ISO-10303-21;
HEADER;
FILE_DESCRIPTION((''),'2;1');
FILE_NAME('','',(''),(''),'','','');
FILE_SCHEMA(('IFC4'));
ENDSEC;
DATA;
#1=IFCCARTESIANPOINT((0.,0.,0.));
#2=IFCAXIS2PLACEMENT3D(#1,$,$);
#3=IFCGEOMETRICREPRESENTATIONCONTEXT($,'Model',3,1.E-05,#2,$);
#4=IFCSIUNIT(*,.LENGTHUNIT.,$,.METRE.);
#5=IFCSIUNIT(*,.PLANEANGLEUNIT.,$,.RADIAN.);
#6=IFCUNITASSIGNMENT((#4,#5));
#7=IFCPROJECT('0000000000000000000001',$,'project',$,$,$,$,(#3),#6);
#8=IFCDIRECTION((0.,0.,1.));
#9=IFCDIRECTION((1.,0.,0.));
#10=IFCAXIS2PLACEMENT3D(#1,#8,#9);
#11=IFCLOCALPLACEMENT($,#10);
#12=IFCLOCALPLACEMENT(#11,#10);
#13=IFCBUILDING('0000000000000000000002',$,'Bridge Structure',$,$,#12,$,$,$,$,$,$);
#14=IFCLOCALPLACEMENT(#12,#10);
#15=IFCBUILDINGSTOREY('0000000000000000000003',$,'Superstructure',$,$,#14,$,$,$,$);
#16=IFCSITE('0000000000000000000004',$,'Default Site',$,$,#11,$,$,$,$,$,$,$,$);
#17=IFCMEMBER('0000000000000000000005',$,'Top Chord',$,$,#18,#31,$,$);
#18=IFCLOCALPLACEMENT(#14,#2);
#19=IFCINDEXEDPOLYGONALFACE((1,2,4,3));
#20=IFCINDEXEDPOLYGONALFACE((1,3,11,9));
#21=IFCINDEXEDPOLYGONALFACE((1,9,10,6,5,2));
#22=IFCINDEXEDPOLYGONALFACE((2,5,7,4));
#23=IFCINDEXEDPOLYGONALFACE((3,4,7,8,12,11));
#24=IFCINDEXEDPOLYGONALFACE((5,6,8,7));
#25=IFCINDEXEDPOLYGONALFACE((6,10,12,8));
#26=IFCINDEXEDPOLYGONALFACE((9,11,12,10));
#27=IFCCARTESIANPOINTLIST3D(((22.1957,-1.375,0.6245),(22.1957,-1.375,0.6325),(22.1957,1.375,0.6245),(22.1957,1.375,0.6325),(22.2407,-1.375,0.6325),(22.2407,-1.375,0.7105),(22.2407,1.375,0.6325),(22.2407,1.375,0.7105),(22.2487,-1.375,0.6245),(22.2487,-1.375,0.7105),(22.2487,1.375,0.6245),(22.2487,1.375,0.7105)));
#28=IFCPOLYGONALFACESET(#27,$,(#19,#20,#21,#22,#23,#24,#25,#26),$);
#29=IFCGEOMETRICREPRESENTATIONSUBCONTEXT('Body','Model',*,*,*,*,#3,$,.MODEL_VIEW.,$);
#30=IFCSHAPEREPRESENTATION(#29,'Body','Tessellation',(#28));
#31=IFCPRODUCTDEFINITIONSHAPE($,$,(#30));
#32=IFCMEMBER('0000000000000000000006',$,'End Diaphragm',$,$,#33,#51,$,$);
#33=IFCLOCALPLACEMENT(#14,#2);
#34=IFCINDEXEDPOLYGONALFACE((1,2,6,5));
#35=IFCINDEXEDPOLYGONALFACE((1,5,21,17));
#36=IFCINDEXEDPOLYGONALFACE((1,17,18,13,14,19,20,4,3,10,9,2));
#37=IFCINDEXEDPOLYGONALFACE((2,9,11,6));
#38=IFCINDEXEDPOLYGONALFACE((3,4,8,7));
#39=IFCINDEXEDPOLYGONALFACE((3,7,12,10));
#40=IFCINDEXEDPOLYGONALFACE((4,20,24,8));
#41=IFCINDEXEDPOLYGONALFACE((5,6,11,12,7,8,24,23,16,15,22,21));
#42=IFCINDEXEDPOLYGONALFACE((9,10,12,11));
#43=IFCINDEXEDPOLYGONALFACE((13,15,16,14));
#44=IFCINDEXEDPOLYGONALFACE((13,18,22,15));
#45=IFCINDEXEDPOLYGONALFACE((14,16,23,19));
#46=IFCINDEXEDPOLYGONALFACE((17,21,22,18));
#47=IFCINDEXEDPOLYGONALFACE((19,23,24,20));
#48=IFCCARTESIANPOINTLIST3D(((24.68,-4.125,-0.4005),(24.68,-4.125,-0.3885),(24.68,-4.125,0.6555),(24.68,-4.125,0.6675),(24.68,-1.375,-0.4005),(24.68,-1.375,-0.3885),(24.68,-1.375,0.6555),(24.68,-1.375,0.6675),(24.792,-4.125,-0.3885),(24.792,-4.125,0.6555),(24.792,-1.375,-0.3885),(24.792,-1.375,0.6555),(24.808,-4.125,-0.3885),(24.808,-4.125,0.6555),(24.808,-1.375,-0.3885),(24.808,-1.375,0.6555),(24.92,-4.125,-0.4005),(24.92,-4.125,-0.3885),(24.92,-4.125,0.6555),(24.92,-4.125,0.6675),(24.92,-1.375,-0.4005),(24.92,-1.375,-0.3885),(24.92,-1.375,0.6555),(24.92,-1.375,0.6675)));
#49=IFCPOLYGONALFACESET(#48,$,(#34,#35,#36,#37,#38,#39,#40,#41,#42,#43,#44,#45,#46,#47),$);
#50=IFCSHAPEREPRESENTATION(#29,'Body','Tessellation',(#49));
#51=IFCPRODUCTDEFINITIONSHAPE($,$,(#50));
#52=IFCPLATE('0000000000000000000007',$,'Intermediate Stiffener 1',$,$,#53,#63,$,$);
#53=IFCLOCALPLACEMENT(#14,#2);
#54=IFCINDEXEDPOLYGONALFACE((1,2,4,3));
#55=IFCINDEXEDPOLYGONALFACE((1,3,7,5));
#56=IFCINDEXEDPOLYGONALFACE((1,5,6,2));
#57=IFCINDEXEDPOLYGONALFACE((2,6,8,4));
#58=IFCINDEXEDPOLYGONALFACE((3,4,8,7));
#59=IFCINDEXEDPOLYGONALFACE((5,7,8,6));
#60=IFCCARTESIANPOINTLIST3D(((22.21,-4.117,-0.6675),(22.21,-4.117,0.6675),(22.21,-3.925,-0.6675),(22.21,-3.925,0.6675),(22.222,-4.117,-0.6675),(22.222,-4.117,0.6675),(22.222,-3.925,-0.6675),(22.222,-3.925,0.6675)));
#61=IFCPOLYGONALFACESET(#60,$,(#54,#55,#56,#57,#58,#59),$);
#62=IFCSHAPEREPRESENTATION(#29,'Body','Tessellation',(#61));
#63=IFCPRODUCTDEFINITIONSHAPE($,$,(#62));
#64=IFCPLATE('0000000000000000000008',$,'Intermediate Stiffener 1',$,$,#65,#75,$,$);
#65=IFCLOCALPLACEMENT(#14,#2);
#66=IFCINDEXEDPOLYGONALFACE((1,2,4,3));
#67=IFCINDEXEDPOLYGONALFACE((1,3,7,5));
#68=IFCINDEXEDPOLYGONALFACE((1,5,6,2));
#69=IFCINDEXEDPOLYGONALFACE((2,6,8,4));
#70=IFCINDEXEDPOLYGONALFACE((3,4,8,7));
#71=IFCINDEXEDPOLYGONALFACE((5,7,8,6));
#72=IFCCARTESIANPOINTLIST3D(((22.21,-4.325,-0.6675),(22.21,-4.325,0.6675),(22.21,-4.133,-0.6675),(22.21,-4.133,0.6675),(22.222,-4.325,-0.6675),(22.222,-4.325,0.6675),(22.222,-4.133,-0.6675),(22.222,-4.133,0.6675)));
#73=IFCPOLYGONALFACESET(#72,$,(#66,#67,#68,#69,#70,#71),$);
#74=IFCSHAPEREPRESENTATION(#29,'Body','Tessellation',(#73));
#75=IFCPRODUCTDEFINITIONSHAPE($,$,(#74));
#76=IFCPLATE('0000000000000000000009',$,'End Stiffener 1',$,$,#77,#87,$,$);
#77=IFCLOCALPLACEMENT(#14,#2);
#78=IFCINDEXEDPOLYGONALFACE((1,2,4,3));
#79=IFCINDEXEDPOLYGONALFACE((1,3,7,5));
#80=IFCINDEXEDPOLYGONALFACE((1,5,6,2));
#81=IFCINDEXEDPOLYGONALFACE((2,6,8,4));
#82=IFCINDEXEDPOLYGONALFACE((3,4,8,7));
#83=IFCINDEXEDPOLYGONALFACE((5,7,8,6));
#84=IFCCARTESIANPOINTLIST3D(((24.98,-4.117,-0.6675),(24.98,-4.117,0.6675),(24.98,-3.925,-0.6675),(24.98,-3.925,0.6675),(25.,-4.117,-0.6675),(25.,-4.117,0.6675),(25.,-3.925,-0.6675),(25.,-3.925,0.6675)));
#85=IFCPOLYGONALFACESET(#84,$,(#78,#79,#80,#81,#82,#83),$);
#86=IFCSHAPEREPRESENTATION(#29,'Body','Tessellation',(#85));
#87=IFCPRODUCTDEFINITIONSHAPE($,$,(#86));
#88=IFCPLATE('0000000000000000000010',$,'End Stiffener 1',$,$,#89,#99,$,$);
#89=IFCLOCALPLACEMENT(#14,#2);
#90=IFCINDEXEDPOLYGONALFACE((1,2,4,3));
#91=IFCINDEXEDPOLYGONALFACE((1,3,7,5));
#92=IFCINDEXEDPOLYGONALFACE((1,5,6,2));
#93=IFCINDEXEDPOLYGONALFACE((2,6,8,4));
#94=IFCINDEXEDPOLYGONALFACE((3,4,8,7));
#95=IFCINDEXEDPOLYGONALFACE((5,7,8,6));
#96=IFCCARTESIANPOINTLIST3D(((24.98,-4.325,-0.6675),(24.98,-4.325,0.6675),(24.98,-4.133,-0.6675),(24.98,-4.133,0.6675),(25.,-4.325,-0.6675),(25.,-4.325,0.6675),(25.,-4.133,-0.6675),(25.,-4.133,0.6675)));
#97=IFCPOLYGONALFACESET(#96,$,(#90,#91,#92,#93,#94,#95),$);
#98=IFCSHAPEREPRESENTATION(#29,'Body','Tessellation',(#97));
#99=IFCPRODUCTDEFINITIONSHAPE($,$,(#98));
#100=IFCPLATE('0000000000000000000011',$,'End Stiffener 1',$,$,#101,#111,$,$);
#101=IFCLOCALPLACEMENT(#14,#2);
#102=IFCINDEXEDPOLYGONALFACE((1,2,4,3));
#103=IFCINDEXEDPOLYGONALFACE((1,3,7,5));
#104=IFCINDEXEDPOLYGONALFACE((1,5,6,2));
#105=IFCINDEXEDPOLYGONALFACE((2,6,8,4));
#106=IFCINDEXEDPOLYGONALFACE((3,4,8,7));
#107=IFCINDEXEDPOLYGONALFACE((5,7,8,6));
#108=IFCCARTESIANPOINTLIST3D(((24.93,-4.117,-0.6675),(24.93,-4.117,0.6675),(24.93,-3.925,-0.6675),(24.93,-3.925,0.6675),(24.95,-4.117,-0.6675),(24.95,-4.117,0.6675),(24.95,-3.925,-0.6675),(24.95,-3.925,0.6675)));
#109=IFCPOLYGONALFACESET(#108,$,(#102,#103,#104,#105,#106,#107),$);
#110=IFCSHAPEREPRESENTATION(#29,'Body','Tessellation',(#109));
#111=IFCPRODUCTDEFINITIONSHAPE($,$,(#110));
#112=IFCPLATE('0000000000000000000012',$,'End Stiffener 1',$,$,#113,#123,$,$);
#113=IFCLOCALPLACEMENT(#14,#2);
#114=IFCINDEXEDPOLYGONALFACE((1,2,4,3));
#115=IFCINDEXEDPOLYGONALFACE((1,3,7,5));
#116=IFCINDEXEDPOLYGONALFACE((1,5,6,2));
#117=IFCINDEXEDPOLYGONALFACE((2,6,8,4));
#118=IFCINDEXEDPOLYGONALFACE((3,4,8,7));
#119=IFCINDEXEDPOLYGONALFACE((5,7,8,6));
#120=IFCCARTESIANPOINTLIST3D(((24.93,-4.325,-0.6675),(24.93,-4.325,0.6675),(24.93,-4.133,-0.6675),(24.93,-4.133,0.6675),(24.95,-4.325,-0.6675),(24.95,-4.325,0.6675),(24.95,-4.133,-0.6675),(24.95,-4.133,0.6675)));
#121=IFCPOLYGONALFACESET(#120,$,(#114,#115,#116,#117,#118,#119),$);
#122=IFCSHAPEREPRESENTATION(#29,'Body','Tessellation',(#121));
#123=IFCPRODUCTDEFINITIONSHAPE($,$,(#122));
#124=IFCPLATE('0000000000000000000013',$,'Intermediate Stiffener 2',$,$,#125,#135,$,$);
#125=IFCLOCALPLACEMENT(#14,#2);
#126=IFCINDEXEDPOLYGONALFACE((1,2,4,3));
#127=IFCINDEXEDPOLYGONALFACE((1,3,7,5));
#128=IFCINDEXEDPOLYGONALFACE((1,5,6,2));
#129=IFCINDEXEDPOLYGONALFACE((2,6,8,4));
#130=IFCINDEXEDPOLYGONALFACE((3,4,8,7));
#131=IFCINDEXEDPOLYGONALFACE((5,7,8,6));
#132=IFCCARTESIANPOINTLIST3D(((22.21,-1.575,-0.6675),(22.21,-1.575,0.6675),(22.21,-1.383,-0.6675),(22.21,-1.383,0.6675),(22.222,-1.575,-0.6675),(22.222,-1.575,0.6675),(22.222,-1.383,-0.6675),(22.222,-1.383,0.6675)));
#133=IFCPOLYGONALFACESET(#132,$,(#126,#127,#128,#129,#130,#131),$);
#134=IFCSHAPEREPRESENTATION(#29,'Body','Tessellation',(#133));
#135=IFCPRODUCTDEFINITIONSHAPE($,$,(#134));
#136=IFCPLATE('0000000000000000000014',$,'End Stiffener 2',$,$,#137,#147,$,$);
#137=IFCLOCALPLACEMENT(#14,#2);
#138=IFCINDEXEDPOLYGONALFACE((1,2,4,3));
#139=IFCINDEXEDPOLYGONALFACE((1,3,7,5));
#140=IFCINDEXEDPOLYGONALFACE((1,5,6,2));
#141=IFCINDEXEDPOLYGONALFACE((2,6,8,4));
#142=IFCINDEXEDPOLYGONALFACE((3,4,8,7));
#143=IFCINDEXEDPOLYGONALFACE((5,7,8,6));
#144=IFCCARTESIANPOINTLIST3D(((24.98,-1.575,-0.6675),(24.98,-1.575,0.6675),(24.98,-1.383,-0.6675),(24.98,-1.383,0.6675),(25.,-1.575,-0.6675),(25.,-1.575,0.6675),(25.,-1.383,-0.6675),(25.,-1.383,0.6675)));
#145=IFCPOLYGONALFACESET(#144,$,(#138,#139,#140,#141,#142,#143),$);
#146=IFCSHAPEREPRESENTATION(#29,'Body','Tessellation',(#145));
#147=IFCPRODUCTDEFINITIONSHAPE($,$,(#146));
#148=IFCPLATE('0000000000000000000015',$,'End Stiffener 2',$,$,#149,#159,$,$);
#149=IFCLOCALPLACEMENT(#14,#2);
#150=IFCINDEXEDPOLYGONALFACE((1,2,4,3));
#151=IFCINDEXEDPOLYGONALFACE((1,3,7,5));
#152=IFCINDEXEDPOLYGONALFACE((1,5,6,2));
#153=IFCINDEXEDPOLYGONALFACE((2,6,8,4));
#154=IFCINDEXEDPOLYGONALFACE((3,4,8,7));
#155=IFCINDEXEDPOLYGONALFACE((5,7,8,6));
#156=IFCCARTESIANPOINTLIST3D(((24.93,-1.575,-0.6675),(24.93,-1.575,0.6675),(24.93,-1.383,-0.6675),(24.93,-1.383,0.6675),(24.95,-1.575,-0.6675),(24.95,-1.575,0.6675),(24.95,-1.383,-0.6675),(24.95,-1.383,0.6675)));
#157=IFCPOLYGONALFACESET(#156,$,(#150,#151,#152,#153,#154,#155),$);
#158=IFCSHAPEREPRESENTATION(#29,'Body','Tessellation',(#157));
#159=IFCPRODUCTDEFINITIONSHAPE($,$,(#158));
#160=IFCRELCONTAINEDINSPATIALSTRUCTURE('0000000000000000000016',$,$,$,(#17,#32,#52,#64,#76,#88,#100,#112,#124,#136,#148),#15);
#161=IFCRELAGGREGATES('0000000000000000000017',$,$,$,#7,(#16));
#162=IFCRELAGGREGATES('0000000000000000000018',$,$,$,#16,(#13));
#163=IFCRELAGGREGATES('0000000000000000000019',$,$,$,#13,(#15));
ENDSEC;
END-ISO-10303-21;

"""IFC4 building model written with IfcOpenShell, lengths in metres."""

from ifc_helpers import new_model, si_unit, frame, origin, origin_with_axes, origin_2d_with_axis, place, context, subcontext, project, spatial, rectangle, i_section, l_section, extrude, element, save


model = new_model("IFC4")

# Units and contexts
model_context = context("Model", 3, precision=1e-05, world=origin())
body_context = subcontext(model_context, "Body", "Model", "MODEL_VIEW")
ifc_project = project(units=[si_unit("LENGTHUNIT", "METRE"), si_unit("PLANEANGLEUNIT", "RADIAN")], contexts=[model_context])

# Site, building, storey
site_placement = place(None, origin_with_axes())
site = spatial("IfcSite", under=ifc_project, at=site_placement, Name="Default Site")
building_placement = place(site_placement, origin_with_axes())
building = spatial("IfcBuilding", under=site, at=building_placement, Name="Bridge Structure")
storey_placement = place(building_placement, origin_with_axes())
storey = spatial("IfcBuildingStorey", under=building, at=storey_placement, Name="Superstructure")

# Members
for number, where, z_axis, x_axis, name in (
    (1, (22.2222, -1.375, 0.6675), (0.0, 1.0, 0.0), (-1.0, 0.0, 0.0), "Top Chord"),
):
    element("IfcMember", number, at=place(storey_placement, frame(where, z_axis=z_axis, x_axis=x_axis)), inside=storey, Name=name, context=body_context, shape_type="SweptSolid", body=[
        extrude(l_section(Depth=0.086, Width=0.053, Thickness=0.008, at=origin_2d_with_axis()), origin_with_axes(), (0.0, 0.0, 1.0), 2.75),
    ])
member_placement = place(storey_placement, frame((24.8, -4.125, 0.1335), z_axis=(0.0, 1.0, 0.0), x_axis=(-1.0, 0.0, 0.0)))
element("IfcMember", 2, at=member_placement, inside=storey, Name="End Diaphragm", context=body_context, shape_type="SweptSolid", body=[
    extrude(i_section(OverallWidth=0.24, OverallDepth=1.068, WebThickness=0.016, FlangeThickness=0.012, at=origin_2d_with_axis()), origin_with_axes(), (0.0, 0.0, 1.0), 2.75),
])

# Plates
for number, where, z_axis, x_axis, name in (
    (3, (22.216, -4.021, -0.6675), (0.0, 0.0, 1.0), (1.0, 0.0, 0.0), "Intermediate Stiffener 1"),
    (4, (22.216, -4.229, -0.6675), (0.0, 0.0, 1.0), (1.0, 0.0, 0.0), "Intermediate Stiffener 1"),
):
    element("IfcPlate", number, at=place(storey_placement, frame(where, z_axis=z_axis, x_axis=x_axis)), inside=storey, Name=name, context=body_context, shape_type="SweptSolid", body=[
        extrude(rectangle(XDim=0.012, YDim=0.192, at=origin_2d_with_axis()), origin_with_axes(), (0.0, 0.0, 1.0), 1.335),
    ])
for number, where, z_axis, x_axis, name in (
    (5, (24.99, -4.021, -0.6675), (0.0, 0.0, 1.0), (1.0, 0.0, 0.0), "End Stiffener 1"),
    (6, (24.99, -4.229, -0.6675), (0.0, 0.0, 1.0), (1.0, 0.0, 0.0), "End Stiffener 1"),
    (7, (24.94, -4.021, -0.6675), (0.0, 0.0, 1.0), (1.0, 0.0, 0.0), "End Stiffener 1"),
    (8, (24.94, -4.229, -0.6675), (0.0, 0.0, 1.0), (1.0, 0.0, 0.0), "End Stiffener 1"),
):
    element("IfcPlate", number, at=place(storey_placement, frame(where, z_axis=z_axis, x_axis=x_axis)), inside=storey, Name=name, context=body_context, shape_type="SweptSolid", body=[
        extrude(rectangle(XDim=0.02, YDim=0.192, at=origin_2d_with_axis()), origin_with_axes(), (0.0, 0.0, 1.0), 1.335),
    ])
plate_placement = place(storey_placement, frame((22.216, -1.479, -0.6675), z_axis=(0.0, 0.0, 1.0), x_axis=(1.0, 0.0, 0.0)))
element("IfcPlate", 9, at=plate_placement, inside=storey, Name="Intermediate Stiffener 2", context=body_context, shape_type="SweptSolid", body=[
    extrude(rectangle(XDim=0.012, YDim=0.192, at=origin_2d_with_axis()), origin_with_axes(), (0.0, 0.0, 1.0), 1.335),
])
for number, where, z_axis, x_axis, name in (
    (10, (24.99, -1.479, -0.6675), (0.0, 0.0, 1.0), (1.0, 0.0, 0.0), "End Stiffener 2"),
    (11, (24.94, -1.479, -0.6675), (0.0, 0.0, 1.0), (1.0, 0.0, 0.0), "End Stiffener 2"),
):
    element("IfcPlate", number, at=place(storey_placement, frame(where, z_axis=z_axis, x_axis=x_axis)), inside=storey, Name=name, context=body_context, shape_type="SweptSolid", body=[
        extrude(rectangle(XDim=0.02, YDim=0.192, at=origin_2d_with_axis()), origin_with_axes(), (0.0, 0.0, 1.0), 1.335),
    ])

save(model, "model.ifc")
